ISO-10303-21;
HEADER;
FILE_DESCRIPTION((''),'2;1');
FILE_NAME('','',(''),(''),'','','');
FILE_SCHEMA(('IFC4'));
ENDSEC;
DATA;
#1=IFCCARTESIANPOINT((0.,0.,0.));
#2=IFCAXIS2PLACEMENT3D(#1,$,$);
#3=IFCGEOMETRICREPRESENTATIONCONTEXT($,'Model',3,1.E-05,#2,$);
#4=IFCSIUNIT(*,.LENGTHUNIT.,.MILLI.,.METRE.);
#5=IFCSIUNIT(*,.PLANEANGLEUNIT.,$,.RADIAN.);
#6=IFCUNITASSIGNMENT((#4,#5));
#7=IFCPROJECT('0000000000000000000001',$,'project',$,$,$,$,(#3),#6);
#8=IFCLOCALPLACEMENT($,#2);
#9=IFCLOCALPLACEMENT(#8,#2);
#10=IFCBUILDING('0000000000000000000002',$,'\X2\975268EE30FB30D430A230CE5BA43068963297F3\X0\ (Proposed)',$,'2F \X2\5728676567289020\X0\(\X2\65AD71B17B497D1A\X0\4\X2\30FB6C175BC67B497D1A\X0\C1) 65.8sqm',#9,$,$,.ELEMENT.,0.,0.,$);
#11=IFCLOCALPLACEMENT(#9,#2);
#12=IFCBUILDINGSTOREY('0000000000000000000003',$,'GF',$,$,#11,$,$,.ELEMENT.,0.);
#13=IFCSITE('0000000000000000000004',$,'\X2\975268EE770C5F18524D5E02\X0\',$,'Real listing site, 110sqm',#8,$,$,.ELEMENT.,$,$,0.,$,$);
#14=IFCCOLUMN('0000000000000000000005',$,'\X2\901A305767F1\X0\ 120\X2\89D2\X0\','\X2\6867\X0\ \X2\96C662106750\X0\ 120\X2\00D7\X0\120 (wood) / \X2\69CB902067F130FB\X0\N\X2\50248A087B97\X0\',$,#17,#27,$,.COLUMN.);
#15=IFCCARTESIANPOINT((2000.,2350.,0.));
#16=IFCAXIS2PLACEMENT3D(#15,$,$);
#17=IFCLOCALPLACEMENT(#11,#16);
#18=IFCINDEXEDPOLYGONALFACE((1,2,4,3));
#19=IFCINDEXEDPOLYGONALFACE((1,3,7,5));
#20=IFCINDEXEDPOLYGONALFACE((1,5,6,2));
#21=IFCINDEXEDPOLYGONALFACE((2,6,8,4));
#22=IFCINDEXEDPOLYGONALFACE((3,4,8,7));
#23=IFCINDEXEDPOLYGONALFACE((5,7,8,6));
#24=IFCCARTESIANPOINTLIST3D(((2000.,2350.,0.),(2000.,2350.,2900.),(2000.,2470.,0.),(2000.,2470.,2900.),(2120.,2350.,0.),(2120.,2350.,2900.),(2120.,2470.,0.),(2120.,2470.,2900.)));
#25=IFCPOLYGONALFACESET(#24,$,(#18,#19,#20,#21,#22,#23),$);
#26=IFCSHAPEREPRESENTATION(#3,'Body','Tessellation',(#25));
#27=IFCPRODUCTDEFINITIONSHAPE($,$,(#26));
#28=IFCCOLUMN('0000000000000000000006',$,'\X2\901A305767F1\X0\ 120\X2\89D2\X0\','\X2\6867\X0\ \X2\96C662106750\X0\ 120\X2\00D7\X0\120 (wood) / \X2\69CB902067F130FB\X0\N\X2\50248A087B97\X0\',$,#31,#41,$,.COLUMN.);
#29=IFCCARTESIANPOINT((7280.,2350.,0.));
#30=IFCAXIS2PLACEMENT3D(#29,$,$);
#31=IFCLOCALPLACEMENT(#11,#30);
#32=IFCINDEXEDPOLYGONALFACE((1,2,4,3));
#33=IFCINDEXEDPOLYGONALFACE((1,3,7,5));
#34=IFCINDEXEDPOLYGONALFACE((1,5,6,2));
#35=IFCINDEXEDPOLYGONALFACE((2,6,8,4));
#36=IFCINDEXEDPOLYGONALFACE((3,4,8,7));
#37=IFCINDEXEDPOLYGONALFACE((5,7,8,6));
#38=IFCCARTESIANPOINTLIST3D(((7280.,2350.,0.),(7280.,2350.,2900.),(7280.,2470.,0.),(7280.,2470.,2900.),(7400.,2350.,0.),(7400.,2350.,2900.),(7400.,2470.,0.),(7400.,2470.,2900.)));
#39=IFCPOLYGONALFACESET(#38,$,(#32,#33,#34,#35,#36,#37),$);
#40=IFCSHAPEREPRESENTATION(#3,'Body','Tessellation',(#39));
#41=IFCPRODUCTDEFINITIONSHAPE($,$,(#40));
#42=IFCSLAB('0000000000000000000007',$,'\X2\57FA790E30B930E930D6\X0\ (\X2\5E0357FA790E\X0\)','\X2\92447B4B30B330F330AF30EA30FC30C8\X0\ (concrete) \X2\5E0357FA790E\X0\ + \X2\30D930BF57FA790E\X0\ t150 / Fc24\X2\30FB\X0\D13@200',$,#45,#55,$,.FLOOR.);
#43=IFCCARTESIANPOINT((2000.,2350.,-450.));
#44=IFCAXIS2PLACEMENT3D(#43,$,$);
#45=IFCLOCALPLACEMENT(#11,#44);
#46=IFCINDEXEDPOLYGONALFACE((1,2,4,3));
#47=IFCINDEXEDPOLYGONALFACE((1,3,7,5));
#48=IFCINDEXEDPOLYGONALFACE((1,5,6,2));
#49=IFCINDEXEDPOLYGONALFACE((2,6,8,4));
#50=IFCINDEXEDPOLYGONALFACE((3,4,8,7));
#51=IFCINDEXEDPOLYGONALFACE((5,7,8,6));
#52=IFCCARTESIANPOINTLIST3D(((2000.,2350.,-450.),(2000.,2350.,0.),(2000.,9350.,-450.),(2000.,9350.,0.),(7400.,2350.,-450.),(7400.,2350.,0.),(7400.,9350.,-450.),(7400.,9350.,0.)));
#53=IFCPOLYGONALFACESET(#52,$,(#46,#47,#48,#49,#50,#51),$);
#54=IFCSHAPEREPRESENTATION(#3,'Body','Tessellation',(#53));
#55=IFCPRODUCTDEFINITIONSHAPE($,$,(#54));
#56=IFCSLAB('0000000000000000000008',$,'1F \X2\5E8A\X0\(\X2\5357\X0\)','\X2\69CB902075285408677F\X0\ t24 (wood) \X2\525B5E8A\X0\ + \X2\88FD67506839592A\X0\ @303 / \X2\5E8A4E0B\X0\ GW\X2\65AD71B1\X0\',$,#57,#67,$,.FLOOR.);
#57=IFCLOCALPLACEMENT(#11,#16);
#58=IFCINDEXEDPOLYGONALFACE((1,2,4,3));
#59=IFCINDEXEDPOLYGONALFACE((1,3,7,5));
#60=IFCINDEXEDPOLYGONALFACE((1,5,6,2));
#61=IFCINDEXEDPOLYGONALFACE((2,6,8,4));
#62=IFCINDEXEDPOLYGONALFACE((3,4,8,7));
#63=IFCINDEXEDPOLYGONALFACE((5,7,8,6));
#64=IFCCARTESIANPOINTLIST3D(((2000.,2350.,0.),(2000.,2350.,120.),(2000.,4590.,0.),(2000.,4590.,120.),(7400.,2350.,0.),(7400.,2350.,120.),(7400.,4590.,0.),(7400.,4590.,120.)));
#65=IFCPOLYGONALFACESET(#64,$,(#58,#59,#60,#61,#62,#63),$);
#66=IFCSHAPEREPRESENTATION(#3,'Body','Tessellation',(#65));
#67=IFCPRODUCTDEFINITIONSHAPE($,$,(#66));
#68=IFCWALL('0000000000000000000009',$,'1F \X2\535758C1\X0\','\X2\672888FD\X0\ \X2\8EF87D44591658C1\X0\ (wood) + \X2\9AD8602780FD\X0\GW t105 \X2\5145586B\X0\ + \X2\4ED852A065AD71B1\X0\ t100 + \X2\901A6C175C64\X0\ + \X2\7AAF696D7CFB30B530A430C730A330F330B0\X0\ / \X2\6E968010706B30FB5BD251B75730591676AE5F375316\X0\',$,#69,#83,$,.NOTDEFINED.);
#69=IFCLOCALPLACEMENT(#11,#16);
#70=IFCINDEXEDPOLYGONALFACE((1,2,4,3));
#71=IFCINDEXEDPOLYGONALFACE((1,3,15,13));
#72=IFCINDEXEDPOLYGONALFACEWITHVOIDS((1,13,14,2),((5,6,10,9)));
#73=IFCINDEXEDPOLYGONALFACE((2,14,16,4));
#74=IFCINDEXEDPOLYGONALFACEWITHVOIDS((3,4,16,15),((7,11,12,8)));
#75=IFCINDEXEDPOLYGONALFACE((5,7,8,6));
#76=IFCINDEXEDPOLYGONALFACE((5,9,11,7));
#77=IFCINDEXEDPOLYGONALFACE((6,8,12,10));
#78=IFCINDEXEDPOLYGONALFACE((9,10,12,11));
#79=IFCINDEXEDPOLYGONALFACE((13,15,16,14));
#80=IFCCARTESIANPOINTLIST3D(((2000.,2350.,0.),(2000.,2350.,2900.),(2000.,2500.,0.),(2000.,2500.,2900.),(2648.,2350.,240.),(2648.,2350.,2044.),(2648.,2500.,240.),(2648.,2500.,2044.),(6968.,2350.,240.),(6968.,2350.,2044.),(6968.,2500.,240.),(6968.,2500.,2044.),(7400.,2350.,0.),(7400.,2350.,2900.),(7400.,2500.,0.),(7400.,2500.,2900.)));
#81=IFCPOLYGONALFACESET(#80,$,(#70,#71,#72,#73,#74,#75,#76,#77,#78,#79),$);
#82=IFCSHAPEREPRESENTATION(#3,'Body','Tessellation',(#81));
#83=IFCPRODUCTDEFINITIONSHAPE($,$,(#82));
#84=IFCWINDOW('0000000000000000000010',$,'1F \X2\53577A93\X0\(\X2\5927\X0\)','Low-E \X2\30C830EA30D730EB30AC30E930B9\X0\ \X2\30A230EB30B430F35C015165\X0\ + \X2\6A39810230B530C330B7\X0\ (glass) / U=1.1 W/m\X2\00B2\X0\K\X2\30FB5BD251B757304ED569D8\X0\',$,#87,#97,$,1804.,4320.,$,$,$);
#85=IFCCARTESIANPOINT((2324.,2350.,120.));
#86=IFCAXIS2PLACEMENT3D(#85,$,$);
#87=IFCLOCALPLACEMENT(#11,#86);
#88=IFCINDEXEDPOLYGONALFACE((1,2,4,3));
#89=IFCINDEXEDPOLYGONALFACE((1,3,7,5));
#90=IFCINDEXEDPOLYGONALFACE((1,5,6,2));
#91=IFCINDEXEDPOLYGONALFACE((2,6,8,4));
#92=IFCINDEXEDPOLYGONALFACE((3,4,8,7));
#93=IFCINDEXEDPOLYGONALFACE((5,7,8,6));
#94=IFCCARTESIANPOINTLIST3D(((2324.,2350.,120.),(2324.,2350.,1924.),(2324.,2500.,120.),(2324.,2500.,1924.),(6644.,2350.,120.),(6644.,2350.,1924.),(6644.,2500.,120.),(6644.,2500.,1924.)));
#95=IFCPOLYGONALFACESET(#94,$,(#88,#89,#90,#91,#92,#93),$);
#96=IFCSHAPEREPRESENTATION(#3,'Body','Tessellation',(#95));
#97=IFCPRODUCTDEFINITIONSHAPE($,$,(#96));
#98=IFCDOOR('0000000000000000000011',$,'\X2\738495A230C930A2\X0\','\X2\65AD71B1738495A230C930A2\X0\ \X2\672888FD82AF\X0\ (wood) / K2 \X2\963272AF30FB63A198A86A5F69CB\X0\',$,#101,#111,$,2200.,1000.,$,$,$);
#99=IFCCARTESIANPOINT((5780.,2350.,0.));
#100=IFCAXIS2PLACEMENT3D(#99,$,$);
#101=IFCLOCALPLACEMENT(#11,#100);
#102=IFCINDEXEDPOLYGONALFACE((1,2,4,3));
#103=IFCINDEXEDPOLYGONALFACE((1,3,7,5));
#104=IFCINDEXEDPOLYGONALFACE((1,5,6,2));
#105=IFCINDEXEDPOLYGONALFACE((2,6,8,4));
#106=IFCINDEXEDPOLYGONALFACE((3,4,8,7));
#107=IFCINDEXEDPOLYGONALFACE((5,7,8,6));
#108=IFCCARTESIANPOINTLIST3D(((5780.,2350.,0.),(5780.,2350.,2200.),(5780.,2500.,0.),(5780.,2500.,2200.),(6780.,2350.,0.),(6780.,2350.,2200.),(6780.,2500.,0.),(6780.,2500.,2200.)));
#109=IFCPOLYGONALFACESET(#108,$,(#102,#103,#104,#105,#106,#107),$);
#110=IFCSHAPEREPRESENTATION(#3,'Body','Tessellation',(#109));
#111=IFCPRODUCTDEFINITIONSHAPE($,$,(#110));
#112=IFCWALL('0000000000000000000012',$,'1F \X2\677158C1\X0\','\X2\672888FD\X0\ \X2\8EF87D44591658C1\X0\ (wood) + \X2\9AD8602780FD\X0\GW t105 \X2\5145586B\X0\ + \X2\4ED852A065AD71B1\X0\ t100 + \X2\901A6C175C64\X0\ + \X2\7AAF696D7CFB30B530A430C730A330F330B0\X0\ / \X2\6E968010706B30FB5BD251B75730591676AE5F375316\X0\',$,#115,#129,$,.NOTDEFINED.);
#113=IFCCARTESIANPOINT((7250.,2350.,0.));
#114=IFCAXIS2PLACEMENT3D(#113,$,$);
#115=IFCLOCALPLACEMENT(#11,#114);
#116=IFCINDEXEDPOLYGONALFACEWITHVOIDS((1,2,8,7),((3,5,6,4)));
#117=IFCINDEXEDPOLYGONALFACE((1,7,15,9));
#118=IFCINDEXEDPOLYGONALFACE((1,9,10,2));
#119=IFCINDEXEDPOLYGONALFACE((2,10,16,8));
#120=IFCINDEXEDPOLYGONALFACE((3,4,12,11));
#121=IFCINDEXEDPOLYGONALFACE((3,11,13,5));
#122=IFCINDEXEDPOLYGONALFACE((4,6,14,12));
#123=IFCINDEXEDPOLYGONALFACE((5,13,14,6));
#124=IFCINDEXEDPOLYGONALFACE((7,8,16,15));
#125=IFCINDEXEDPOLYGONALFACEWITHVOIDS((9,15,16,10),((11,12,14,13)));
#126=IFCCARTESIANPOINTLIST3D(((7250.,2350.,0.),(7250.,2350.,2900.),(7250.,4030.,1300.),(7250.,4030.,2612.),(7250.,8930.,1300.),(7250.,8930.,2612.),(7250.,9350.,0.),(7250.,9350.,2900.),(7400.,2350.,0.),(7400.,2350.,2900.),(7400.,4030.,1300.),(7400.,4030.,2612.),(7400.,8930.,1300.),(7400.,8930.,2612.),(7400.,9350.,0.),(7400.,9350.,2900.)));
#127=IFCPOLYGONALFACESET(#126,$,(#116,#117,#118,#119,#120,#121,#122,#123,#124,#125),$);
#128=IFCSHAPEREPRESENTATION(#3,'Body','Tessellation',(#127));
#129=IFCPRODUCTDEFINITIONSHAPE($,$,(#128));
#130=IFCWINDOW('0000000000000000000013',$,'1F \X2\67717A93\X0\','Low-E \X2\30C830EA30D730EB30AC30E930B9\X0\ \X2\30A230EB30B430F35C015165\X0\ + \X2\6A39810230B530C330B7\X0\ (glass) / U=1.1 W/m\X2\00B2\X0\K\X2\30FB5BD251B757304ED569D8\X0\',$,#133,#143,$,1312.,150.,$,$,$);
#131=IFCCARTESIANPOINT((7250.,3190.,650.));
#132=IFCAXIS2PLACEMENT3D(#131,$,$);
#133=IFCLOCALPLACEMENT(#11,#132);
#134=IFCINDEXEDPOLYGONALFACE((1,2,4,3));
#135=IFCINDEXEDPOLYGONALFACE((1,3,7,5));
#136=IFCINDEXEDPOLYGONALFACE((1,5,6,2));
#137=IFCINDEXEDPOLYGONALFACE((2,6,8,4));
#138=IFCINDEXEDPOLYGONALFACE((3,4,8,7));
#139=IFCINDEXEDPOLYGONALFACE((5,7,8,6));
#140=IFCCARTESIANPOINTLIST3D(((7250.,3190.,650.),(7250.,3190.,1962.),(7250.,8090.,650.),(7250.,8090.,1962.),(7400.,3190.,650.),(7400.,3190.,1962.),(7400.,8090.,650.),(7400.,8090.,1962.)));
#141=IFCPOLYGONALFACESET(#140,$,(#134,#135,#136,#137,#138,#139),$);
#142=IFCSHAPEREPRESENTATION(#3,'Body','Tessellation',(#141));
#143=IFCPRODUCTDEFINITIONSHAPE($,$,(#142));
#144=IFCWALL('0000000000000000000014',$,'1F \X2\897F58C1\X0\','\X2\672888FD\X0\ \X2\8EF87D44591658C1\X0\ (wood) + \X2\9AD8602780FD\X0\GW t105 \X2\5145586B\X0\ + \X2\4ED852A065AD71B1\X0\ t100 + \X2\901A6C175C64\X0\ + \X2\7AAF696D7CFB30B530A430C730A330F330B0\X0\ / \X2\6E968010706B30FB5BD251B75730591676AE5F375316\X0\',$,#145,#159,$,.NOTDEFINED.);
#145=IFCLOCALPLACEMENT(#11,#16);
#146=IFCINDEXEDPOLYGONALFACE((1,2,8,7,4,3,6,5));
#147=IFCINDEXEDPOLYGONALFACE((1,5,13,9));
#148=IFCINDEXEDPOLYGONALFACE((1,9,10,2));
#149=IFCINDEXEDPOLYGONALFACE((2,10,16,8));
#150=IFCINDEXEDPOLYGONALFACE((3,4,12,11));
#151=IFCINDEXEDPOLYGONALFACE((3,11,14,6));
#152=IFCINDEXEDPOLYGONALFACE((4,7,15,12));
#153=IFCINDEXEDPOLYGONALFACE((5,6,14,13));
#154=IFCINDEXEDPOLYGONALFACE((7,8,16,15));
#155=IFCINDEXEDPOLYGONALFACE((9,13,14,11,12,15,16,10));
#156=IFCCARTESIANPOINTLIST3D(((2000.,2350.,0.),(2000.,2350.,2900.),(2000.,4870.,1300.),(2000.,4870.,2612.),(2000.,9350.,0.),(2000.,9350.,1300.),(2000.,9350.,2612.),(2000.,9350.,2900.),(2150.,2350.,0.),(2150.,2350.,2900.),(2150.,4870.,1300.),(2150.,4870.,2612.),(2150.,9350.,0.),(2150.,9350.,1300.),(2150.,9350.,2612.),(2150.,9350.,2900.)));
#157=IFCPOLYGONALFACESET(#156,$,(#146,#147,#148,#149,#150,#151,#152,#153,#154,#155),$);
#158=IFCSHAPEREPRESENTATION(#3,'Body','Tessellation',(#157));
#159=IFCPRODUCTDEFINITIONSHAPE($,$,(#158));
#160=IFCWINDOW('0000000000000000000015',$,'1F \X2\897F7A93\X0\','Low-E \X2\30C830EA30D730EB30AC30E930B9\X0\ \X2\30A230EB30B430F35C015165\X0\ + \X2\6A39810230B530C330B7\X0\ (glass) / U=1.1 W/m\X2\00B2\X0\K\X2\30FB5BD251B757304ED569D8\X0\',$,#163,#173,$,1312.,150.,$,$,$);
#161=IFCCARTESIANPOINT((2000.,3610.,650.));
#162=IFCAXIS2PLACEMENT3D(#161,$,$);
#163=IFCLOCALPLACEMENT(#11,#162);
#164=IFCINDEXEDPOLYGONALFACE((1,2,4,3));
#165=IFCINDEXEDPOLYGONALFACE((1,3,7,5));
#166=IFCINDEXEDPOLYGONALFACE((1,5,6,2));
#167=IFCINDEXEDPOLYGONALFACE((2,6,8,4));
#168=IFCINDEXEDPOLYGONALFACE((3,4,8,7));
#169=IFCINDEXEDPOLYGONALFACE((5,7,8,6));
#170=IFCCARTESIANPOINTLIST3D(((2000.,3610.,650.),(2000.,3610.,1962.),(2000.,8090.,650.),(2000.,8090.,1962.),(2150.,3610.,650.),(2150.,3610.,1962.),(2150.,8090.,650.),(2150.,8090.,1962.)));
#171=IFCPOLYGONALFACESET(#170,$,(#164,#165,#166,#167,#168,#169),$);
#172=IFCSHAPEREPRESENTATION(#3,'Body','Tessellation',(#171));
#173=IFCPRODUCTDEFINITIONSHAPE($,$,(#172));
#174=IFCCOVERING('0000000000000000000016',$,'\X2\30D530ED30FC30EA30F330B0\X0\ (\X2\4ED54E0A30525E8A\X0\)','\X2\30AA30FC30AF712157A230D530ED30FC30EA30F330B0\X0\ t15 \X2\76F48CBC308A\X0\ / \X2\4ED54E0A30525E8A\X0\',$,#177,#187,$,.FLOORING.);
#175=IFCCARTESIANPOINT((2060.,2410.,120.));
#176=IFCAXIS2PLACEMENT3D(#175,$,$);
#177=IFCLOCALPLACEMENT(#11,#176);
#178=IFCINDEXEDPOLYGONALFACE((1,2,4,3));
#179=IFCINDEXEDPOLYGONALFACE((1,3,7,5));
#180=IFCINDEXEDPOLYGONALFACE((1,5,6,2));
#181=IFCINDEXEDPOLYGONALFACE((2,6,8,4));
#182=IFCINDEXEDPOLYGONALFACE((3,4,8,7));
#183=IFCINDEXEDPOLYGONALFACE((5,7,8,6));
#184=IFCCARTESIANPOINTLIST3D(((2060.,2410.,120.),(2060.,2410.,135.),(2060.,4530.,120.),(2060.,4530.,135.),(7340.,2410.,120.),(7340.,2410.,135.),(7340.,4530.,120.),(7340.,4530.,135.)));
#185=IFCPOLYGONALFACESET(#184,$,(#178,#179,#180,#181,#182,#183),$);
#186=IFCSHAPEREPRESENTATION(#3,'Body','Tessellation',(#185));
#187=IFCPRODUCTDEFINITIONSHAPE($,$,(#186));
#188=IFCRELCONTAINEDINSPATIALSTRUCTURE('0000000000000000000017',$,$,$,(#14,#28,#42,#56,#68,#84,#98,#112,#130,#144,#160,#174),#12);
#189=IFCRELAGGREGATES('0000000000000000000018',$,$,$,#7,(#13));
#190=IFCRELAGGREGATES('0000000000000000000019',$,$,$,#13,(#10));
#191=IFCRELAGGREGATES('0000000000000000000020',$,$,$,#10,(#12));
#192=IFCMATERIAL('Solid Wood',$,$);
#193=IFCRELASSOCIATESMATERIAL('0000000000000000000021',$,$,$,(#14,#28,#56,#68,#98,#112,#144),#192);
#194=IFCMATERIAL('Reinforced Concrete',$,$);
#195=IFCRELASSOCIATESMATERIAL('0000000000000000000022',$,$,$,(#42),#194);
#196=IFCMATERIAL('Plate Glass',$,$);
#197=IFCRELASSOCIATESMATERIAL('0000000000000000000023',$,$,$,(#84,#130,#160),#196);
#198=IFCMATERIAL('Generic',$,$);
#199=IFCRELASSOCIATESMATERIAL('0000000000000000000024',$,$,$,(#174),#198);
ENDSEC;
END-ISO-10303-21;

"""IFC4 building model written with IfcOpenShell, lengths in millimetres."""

from ifc_helpers import new_model, si_unit, frame, frame_2d, origin, place, context, project, spatial, rectangle, extrude, material, element, fill, save


model = new_model("IFC4")

# Units and contexts
model_context = context("Model", 3, precision=1e-05, world=origin())
ifc_project = project(units=[si_unit("LENGTHUNIT", "METRE", prefix="MILLI"), si_unit("PLANEANGLEUNIT", "RADIAN")], contexts=[model_context])

# Site, building, storey
site_placement = place(None, origin())
site = spatial("IfcSite", under=ifc_project, at=site_placement, Name="青森県弘前市", ObjectType="Real listing site, 110sqm", CompositionType="ELEMENT", RefElevation=0.0)
building_placement = place(site_placement, origin())
building = spatial("IfcBuilding", under=site, at=building_placement, Name="青森・ピアノ室と防音 (Proposed)", ObjectType="2F 在来木造(断熱等級4・気密等級C1) 65.8sqm", CompositionType="ELEMENT", ElevationOfRefHeight=0.0, ElevationOfTerrain=0.0)
storey_placement = place(building_placement, origin())
storey = spatial("IfcBuildingStorey", under=building, at=storey_placement, Name="GF", CompositionType="ELEMENT", Elevation=0.0)

# Columns
ifc_material_1 = material(Name="Solid Wood")
column_1_placement = place(storey_placement, frame((2000.0, 2350.0, 0.0)))
element("IfcColumn", 1, at=column_1_placement, inside=storey, material=ifc_material_1, Name="通し柱 120角", Description="桧 集成材 120×120 (wood) / 構造柱・N値計算", PredefinedType="COLUMN", context=model_context, shape_type="SweptSolid", body=[
    extrude(rectangle(XDim=120.0, YDim=120.0, at=frame_2d((60.0, 60.0))), frame((2000.0, 2350.0, 0.0)), (0.0, 0.0, 1.0), 2900.0),
])
column_2_placement = place(storey_placement, frame((7280.0, 2350.0, 0.0)))
element("IfcColumn", 2, at=column_2_placement, inside=storey, material=ifc_material_1, Name="通し柱 120角", Description="桧 集成材 120×120 (wood) / 構造柱・N値計算", PredefinedType="COLUMN", context=model_context, shape_type="SweptSolid", body=[
    extrude(rectangle(XDim=120.0, YDim=120.0, at=frame_2d((60.0, 60.0))), frame((7280.0, 2350.0, 0.0)), (0.0, 0.0, 1.0), 2900.0),
])

# Slabs
ifc_material_2 = material(Name="Reinforced Concrete")
slab_1_placement = place(storey_placement, frame((2000.0, 2350.0, -450.0)))
element("IfcSlab", 3, at=slab_1_placement, inside=storey, material=ifc_material_2, Name="基礎スラブ (布基礎)", Description="鉄筋コンクリート (concrete) 布基礎 + ベタ基礎 t150 / Fc24・D13@200", PredefinedType="FLOOR", context=model_context, shape_type="SweptSolid", body=[
    extrude(rectangle(XDim=5400.0, YDim=7000.0, at=frame_2d((2700.0, 3500.0))), frame((2000.0, 2350.0, -450.0)), (0.0, 0.0, 1.0), 450.0),
])
slab_2_placement = place(storey_placement, frame((2000.0, 2350.0, 0.0)))
element("IfcSlab", 4, at=slab_2_placement, inside=storey, material=ifc_material_1, Name="1F 床(南)", Description="構造用合板 t24 (wood) 剛床 + 製材根太 @303 / 床下 GW断熱", PredefinedType="FLOOR", context=model_context, shape_type="SweptSolid", body=[
    extrude(rectangle(XDim=5400.0, YDim=2240.0, at=frame_2d((2700.0, 1120.0))), frame((2000.0, 2350.0, 0.0)), (0.0, 0.0, 1.0), 120.0),
])

# Wall, openings, window, door
wall_1_placement = place(storey_placement, frame((2000.0, 2350.0, 0.0)))
wall_1 = element("IfcWall", 5, at=wall_1_placement, inside=storey, material=ifc_material_1, Name="1F 南壁", Description="木製 軸組外壁 (wood) + 高性能GW t105 充填 + 付加断熱 t100 + 通気層 + 窯業系サイディング / 準耐火・寒冷地外皮強化", PredefinedType="NOTDEFINED", context=model_context, shape_type="SweptSolid", body=[
    extrude(rectangle(XDim=5400.0, YDim=150.0, at=frame_2d((2700.0, 75.0))), frame((2000.0, 2350.0, 0.0)), (0.0, 0.0, 1.0), 2900.0),
])
opening_1_placement = place(storey_placement, frame((2324.0, 2350.0, 120.0)))
opening_1 = element("IfcOpeningElement", 6, at=opening_1_placement, cuts=wall_1, PredefinedType="NOTDEFINED", context=model_context, shape_type="SweptSolid", body=[
    extrude(rectangle(XDim=4320.0, YDim=150.0, at=frame_2d((2160.0, 75.0))), frame((2324.0, 2350.0, 120.0)), (0.0, 0.0, 1.0), 1804.0),
])
opening_2_placement = place(storey_placement, frame((5780.0, 2350.0, 0.0)))
opening_2 = element("IfcOpeningElement", 7, at=opening_2_placement, cuts=wall_1, PredefinedType="NOTDEFINED", context=model_context, shape_type="SweptSolid", body=[
    extrude(rectangle(XDim=1000.0, YDim=150.0, at=frame_2d((500.0, 75.0))), frame((5780.0, 2350.0, 0.0)), (0.0, 0.0, 1.0), 2200.0),
])
ifc_material_3 = material(Name="Plate Glass")
window_1_placement = place(storey_placement, frame((2324.0, 2350.0, 120.0)))
window_1 = element("IfcWindow", 8, at=window_1_placement, inside=storey, material=ifc_material_3, Name="1F 南窓(大)", Description="Low-E トリプルガラス アルゴン封入 + 樹脂サッシ (glass) / U=1.1 W/m²K・寒冷地仕様", OverallHeight=1804.0, OverallWidth=4320.0, context=model_context, shape_type="SweptSolid", body=[
    extrude(rectangle(XDim=4320.0, YDim=150.0, at=frame_2d((2160.0, 75.0))), frame((2324.0, 2350.0, 120.0)), (0.0, 0.0, 1.0), 1804.0),
])
fill(opening_1, window_1)
door_placement = place(storey_placement, frame((5780.0, 2350.0, 0.0)))
door = element("IfcDoor", 9, at=door_placement, inside=storey, material=ifc_material_1, Name="玄関ドア", Description="断熱玄関ドア 木製芯 (wood) / K2 防犯・採風機構", OverallHeight=2200.0, OverallWidth=1000.0, context=model_context, shape_type="SweptSolid", body=[
    extrude(rectangle(XDim=1000.0, YDim=150.0, at=frame_2d((500.0, 75.0))), frame((5780.0, 2350.0, 0.0)), (0.0, 0.0, 1.0), 2200.0),
])
fill(opening_2, door)

# Walls, openings, windows
wall_2_placement = place(storey_placement, frame((7250.0, 2350.0, 0.0)))
wall_2 = element("IfcWall", 10, at=wall_2_placement, inside=storey, material=ifc_material_1, Name="1F 東壁", Description="木製 軸組外壁 (wood) + 高性能GW t105 充填 + 付加断熱 t100 + 通気層 + 窯業系サイディング / 準耐火・寒冷地外皮強化", PredefinedType="NOTDEFINED", context=model_context, shape_type="SweptSolid", body=[
    extrude(rectangle(XDim=150.0, YDim=7000.0, at=frame_2d((75.0, 3500.0))), frame((7250.0, 2350.0, 0.0)), (0.0, 0.0, 1.0), 2900.0),
])
opening_3_placement = place(storey_placement, frame((7250.0, 3190.0, 650.0)))
opening_3 = element("IfcOpeningElement", 11, at=opening_3_placement, cuts=wall_2, PredefinedType="NOTDEFINED", context=model_context, shape_type="SweptSolid", body=[
    extrude(rectangle(XDim=150.0, YDim=4900.0, at=frame_2d((75.0, 2450.0))), frame((7250.0, 3190.0, 650.0)), (0.0, 0.0, 1.0), 1312.0),
])
window_2_placement = place(storey_placement, frame((7250.0, 3190.0, 650.0)))
window_2 = element("IfcWindow", 12, at=window_2_placement, inside=storey, material=ifc_material_3, Name="1F 東窓", Description="Low-E トリプルガラス アルゴン封入 + 樹脂サッシ (glass) / U=1.1 W/m²K・寒冷地仕様", OverallHeight=1312.0, OverallWidth=150.0, context=model_context, shape_type="SweptSolid", body=[
    extrude(rectangle(XDim=150.0, YDim=4900.0, at=frame_2d((75.0, 2450.0))), frame((7250.0, 3190.0, 650.0)), (0.0, 0.0, 1.0), 1312.0),
])
fill(opening_3, window_2)
wall_3_placement = place(storey_placement, frame((2000.0, 2350.0, 0.0)))
wall_3 = element("IfcWall", 13, at=wall_3_placement, inside=storey, material=ifc_material_1, Name="1F 西壁", Description="木製 軸組外壁 (wood) + 高性能GW t105 充填 + 付加断熱 t100 + 通気層 + 窯業系サイディング / 準耐火・寒冷地外皮強化", PredefinedType="NOTDEFINED", context=model_context, shape_type="SweptSolid", body=[
    extrude(rectangle(XDim=150.0, YDim=7000.0, at=frame_2d((75.0, 3500.0))), frame((2000.0, 2350.0, 0.0)), (0.0, 0.0, 1.0), 2900.0),
])
opening_4_placement = place(storey_placement, frame((2000.0, 3610.0, 650.0)))
opening_4 = element("IfcOpeningElement", 14, at=opening_4_placement, cuts=wall_3, PredefinedType="NOTDEFINED", context=model_context, shape_type="SweptSolid", body=[
    extrude(rectangle(XDim=150.0, YDim=4480.0, at=frame_2d((75.0, 2240.0))), frame((2000.0, 3610.0, 650.0)), (0.0, 0.0, 1.0), 1312.0),
])
window_3_placement = place(storey_placement, frame((2000.0, 3610.0, 650.0)))
window_3 = element("IfcWindow", 15, at=window_3_placement, inside=storey, material=ifc_material_3, Name="1F 西窓", Description="Low-E トリプルガラス アルゴン封入 + 樹脂サッシ (glass) / U=1.1 W/m²K・寒冷地仕様", OverallHeight=1312.0, OverallWidth=150.0, context=model_context, shape_type="SweptSolid", body=[
    extrude(rectangle(XDim=150.0, YDim=4480.0, at=frame_2d((75.0, 2240.0))), frame((2000.0, 3610.0, 650.0)), (0.0, 0.0, 1.0), 1312.0),
])
fill(opening_4, window_3)

# Covering
ifc_material_4 = material(Name="Generic")
covering_1_placement = place(storey_placement, frame((2060.0, 2410.0, 120.0)))
element("IfcCovering", 16, at=covering_1_placement, inside=storey, material=ifc_material_4, Name="フローリング (仕上げ床)", Description="オーク無垢フローリング t15 直貼り / 仕上げ床", PredefinedType="FLOORING", context=model_context, shape_type="SweptSolid", body=[
    extrude(rectangle(XDim=5280.0, YDim=2120.0, at=frame_2d((2640.0, 1060.0))), frame((2060.0, 2410.0, 120.0)), (0.0, 0.0, 1.0), 15.0),
])

save(model, "model.ifc")
